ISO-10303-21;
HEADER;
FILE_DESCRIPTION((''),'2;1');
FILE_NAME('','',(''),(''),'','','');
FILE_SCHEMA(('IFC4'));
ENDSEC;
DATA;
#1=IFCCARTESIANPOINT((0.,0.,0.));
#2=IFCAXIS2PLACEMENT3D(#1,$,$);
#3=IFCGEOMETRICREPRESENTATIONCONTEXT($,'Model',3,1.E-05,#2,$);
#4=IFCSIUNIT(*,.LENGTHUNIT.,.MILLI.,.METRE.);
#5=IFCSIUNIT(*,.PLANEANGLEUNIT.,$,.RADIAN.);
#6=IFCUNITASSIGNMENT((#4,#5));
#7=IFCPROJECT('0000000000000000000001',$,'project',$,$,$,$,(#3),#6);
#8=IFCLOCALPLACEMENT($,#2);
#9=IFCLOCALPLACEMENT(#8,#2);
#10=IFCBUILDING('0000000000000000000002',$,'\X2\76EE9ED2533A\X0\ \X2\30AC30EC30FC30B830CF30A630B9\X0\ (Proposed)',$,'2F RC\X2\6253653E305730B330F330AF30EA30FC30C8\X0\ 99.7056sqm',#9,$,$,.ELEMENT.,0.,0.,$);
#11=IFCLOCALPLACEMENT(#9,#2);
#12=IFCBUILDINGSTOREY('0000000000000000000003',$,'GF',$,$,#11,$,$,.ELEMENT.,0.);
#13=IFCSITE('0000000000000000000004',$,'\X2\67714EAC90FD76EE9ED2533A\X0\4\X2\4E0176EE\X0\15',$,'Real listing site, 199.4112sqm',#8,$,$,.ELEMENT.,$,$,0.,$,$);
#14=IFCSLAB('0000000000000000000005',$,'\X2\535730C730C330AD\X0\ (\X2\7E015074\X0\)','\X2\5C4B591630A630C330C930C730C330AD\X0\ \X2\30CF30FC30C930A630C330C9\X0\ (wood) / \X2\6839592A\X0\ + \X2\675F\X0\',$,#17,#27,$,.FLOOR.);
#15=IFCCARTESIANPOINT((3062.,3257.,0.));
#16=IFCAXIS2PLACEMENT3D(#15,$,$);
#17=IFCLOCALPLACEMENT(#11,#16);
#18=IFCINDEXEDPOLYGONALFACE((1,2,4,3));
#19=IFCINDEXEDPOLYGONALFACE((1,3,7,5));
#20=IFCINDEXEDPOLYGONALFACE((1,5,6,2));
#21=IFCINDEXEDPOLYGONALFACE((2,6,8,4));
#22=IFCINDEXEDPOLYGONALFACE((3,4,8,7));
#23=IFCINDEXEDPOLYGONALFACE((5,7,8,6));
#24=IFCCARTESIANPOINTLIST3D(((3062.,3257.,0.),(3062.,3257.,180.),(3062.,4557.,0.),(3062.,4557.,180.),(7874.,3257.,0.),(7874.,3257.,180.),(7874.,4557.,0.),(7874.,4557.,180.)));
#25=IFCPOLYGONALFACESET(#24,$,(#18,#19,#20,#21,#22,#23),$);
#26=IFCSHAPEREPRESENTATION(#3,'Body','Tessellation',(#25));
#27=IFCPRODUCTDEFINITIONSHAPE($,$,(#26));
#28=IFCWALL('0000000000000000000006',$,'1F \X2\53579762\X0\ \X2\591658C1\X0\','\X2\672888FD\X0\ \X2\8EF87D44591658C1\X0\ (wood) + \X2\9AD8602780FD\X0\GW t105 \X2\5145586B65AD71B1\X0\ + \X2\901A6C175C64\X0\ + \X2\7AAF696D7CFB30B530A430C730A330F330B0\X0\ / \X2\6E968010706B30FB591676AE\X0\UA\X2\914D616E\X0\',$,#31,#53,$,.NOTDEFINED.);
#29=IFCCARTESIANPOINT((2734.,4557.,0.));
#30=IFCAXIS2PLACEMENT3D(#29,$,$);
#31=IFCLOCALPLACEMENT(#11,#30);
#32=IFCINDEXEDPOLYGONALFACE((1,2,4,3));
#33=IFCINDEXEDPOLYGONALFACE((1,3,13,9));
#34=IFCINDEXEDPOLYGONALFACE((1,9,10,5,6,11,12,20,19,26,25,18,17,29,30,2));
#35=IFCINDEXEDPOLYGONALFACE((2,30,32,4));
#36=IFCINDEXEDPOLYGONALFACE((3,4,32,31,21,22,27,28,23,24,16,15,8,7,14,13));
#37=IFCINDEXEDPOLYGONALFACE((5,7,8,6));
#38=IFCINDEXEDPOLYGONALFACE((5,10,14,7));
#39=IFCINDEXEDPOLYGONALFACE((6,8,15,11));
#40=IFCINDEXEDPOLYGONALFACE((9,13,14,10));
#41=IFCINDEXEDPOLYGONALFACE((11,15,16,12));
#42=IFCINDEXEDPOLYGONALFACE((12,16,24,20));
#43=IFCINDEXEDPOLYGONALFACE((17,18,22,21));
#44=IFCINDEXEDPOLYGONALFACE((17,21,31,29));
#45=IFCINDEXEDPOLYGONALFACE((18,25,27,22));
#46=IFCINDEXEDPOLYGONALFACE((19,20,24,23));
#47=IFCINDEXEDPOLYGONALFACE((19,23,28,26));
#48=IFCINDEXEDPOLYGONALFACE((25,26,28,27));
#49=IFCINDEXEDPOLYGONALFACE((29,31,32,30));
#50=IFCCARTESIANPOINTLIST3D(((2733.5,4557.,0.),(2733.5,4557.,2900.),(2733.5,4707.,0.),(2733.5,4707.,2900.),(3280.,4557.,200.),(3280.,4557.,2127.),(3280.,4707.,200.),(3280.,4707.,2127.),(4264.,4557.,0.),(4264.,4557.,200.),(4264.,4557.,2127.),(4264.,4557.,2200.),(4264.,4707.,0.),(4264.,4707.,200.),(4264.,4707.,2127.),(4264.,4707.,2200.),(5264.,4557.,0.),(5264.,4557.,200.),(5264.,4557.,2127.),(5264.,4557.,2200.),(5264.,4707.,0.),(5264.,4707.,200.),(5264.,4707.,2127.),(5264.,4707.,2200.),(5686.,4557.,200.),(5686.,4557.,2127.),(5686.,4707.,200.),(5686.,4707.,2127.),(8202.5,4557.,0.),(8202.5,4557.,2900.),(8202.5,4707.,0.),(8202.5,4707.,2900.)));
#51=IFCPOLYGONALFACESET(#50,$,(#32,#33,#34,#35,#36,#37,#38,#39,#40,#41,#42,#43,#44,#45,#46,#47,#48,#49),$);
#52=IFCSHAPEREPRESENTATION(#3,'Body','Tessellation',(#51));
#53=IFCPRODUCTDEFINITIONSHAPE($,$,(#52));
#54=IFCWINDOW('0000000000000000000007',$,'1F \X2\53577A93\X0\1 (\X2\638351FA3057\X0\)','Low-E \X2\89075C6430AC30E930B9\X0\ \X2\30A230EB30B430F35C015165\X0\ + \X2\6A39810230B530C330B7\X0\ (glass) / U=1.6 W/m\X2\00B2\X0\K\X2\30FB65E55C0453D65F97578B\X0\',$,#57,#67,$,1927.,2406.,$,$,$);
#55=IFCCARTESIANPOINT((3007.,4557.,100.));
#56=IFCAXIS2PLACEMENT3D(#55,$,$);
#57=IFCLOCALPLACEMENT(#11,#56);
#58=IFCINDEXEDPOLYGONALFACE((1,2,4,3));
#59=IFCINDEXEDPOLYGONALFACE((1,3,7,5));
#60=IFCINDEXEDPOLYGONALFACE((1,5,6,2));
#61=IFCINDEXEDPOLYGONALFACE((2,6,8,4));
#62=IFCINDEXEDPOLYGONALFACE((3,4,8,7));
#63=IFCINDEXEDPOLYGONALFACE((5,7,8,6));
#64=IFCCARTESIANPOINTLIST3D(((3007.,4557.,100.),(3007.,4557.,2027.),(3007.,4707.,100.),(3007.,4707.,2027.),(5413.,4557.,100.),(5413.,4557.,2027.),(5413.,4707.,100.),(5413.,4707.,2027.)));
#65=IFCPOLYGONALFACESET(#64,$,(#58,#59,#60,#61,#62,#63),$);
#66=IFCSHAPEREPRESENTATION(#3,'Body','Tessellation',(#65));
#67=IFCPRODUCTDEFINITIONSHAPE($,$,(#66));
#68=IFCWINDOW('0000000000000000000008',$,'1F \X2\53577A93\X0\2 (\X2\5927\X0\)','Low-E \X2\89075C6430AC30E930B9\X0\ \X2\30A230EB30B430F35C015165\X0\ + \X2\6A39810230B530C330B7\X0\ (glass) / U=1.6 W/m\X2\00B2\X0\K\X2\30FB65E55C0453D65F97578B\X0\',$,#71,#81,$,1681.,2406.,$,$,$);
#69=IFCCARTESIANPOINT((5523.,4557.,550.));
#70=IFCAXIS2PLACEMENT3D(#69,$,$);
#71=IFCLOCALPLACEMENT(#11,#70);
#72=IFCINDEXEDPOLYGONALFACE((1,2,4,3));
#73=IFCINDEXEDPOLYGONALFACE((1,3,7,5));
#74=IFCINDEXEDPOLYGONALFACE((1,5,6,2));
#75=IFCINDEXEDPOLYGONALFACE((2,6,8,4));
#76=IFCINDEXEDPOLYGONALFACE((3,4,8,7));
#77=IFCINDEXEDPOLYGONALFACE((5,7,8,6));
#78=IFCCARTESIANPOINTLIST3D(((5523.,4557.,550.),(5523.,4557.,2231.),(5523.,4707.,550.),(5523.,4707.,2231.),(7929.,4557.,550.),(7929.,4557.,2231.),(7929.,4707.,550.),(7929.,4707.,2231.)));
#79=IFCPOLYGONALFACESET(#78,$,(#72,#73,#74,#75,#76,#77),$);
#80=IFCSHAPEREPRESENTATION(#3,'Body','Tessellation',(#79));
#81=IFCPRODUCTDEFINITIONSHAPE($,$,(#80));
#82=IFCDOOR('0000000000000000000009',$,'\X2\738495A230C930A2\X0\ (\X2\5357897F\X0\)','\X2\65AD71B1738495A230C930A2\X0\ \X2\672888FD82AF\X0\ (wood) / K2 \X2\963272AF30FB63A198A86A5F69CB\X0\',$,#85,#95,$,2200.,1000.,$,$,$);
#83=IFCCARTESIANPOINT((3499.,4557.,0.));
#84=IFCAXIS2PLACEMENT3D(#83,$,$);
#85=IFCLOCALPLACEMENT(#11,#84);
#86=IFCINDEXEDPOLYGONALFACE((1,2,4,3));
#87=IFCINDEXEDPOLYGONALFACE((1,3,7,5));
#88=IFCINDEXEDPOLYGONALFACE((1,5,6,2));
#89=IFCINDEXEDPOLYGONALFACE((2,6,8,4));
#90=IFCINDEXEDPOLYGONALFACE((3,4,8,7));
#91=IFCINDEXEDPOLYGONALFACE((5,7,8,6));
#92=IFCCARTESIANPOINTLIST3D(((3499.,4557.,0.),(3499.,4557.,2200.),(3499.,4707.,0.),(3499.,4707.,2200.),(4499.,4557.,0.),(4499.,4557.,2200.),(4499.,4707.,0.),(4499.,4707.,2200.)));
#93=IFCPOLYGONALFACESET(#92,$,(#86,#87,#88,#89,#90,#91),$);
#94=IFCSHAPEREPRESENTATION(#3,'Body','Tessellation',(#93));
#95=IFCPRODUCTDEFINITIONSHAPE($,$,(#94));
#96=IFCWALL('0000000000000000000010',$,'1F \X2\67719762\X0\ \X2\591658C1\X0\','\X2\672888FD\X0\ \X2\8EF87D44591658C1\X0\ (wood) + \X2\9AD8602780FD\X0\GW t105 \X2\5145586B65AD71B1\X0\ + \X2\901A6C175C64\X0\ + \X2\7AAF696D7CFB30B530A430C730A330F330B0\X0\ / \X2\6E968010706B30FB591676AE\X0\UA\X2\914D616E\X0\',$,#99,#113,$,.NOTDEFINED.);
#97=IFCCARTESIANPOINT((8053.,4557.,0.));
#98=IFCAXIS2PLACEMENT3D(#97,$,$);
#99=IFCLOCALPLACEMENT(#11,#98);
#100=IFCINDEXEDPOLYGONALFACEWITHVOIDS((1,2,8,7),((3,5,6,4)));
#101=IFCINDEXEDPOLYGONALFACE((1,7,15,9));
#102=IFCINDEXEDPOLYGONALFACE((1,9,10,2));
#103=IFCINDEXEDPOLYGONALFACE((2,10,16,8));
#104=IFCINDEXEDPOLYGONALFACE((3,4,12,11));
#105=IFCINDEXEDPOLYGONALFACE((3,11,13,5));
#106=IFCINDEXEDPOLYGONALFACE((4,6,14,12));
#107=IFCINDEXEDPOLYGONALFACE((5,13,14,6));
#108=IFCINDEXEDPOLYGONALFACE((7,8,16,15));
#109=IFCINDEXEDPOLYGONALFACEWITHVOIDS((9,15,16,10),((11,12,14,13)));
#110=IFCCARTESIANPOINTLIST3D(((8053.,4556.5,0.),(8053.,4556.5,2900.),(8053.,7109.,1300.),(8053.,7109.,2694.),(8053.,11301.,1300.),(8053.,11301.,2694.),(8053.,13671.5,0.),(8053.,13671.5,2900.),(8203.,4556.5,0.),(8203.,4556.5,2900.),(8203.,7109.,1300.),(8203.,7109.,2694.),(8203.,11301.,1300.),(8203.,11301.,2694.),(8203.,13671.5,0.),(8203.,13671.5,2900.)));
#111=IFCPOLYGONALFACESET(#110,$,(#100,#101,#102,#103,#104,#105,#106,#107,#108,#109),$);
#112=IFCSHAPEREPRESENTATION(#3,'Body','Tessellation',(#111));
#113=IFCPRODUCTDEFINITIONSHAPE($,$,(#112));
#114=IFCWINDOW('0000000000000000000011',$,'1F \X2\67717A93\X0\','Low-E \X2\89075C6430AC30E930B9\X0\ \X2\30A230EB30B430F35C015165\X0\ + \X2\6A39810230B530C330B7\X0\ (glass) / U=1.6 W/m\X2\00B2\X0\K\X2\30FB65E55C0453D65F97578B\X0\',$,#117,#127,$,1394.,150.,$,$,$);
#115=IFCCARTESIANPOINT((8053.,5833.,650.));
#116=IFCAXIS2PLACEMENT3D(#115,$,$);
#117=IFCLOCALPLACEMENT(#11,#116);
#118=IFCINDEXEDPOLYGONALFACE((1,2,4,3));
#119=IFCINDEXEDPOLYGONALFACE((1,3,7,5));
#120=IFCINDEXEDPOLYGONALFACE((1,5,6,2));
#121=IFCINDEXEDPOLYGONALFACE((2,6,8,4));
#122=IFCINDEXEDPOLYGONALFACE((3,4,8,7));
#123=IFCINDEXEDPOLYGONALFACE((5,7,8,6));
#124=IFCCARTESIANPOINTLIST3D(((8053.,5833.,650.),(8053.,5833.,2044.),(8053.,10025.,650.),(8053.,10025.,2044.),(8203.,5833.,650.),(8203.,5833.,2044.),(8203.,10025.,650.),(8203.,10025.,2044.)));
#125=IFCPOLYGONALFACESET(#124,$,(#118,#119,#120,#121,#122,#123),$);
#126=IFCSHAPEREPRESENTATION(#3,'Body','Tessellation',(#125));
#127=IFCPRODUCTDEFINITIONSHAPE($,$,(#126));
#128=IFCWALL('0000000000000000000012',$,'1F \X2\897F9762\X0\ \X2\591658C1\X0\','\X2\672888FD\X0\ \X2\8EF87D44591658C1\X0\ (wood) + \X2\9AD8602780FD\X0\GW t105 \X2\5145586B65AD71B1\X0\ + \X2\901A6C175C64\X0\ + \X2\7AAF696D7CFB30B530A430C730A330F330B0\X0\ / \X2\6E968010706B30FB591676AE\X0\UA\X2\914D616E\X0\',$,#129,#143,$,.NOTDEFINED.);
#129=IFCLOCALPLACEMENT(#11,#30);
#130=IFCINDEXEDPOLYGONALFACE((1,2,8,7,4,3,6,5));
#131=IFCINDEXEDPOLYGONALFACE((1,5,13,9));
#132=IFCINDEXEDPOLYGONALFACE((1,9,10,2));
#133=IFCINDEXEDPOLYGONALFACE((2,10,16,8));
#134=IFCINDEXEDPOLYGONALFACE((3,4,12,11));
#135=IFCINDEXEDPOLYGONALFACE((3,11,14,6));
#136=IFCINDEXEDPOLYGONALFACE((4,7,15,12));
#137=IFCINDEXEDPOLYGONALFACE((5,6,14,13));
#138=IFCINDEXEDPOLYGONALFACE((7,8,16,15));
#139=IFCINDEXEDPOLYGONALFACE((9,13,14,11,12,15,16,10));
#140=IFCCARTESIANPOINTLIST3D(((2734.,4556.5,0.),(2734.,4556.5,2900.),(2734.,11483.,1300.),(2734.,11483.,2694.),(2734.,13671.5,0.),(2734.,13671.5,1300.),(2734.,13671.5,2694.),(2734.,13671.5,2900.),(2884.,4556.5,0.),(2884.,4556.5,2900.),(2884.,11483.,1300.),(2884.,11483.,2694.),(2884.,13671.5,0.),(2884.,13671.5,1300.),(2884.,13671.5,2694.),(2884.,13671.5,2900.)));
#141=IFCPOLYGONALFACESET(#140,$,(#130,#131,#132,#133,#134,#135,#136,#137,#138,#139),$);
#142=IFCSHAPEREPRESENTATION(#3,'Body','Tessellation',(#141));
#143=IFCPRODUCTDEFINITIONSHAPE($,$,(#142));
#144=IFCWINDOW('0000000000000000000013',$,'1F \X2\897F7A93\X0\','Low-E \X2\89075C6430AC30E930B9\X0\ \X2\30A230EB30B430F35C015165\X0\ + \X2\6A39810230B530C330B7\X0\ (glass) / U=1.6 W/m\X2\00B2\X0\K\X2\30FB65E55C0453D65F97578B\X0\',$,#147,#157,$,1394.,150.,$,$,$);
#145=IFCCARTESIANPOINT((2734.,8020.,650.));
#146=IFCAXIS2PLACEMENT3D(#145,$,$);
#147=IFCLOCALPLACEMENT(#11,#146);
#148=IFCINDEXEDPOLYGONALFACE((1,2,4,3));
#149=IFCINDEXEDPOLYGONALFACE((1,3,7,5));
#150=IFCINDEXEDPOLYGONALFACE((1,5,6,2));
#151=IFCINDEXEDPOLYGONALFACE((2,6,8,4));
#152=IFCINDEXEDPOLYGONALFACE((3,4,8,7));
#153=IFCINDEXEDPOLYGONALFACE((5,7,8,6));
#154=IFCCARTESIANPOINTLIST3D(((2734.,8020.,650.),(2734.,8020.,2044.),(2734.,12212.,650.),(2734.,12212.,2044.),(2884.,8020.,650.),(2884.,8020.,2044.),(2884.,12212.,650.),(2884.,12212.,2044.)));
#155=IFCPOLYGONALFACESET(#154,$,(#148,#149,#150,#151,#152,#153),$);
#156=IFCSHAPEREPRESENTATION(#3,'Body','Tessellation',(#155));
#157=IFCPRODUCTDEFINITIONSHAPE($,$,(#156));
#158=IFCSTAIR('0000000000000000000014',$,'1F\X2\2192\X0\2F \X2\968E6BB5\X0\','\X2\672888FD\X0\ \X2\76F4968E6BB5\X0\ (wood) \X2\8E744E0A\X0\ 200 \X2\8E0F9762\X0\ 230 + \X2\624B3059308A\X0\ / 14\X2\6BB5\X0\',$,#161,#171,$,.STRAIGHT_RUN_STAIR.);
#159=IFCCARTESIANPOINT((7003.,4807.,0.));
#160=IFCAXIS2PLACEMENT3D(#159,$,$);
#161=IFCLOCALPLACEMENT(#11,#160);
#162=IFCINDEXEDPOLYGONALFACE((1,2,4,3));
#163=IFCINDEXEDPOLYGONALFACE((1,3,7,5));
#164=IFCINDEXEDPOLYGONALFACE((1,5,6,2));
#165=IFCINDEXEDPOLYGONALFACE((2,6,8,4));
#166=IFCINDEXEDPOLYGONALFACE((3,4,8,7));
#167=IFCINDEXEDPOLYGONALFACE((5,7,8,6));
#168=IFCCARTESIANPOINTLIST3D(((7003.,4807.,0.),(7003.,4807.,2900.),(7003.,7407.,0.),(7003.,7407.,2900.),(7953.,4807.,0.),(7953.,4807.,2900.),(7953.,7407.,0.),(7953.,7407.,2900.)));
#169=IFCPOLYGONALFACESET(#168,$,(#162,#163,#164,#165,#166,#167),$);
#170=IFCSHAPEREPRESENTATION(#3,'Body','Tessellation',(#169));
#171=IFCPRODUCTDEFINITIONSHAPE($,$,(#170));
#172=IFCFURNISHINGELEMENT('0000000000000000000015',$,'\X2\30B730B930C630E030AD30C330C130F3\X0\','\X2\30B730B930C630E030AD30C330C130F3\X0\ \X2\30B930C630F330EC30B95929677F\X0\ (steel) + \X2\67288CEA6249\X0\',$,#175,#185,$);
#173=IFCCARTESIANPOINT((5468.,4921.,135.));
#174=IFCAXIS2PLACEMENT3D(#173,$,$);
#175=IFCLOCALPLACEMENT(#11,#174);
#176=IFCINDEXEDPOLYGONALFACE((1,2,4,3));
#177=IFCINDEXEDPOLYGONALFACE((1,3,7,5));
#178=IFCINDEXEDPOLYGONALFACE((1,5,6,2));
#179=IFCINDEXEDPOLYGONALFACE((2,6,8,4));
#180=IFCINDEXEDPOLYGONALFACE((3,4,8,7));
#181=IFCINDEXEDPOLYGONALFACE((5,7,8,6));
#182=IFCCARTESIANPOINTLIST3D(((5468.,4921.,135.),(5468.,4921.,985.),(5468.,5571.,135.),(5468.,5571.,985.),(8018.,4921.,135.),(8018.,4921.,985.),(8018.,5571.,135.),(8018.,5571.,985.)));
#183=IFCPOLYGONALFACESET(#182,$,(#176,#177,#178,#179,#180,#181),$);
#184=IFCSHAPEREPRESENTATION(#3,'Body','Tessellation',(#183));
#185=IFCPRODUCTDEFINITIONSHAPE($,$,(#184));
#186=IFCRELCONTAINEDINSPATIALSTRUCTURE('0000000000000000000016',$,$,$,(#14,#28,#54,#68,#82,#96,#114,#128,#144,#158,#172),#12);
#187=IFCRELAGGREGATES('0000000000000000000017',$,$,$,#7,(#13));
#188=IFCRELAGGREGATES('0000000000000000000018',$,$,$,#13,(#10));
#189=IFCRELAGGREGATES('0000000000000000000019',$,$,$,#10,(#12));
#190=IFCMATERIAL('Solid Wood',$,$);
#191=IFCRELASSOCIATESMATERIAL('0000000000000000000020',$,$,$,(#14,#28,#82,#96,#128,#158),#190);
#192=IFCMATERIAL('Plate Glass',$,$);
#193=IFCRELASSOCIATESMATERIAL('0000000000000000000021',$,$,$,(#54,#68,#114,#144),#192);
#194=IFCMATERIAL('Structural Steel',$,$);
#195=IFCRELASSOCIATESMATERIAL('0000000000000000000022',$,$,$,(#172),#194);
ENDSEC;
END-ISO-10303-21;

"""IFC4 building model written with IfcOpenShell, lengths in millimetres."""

from ifc_helpers import new_model, si_unit, frame, frame_2d, origin, place, context, project, spatial, rectangle, extrude, material, element, fill, save


model = new_model("IFC4")

# Units and contexts
model_context = context("Model", 3, precision=1e-05, world=origin())
ifc_project = project(units=[si_unit("LENGTHUNIT", "METRE", prefix="MILLI"), si_unit("PLANEANGLEUNIT", "RADIAN")], contexts=[model_context])

# Site, building, storey
site_placement = place(None, origin())
site = spatial("IfcSite", under=ifc_project, at=site_placement, Name="東京都目黒区4丁目15", ObjectType="Real listing site, 199.4112sqm", CompositionType="ELEMENT", RefElevation=0.0)
building_placement = place(site_placement, origin())
building = spatial("IfcBuilding", under=site, at=building_placement, Name="目黒区 ガレージハウス (Proposed)", ObjectType="2F RC打放しコンクリート 99.7056sqm", CompositionType="ELEMENT", ElevationOfRefHeight=0.0, ElevationOfTerrain=0.0)
storey_placement = place(building_placement, origin())
storey = spatial("IfcBuildingStorey", under=building, at=storey_placement, Name="GF", CompositionType="ELEMENT", Elevation=0.0)

# Slab
ifc_material_1 = material(Name="Solid Wood")
slab_1_placement = place(storey_placement, frame((3062.0, 3257.0, 0.0)))
element("IfcSlab", 1, at=slab_1_placement, inside=storey, material=ifc_material_1, Name="南デッキ (縁側)", Description="屋外ウッドデッキ ハードウッド (wood) / 根太 + 束", PredefinedType="FLOOR", context=model_context, shape_type="SweptSolid", body=[
    extrude(rectangle(XDim=4812.0, YDim=1300.0, at=frame_2d((2406.0, 650.0))), frame((3062.0, 3257.0, 0.0)), (0.0, 0.0, 1.0), 180.0),
])

# Wall, openings, windows, door
wall_1_placement = place(storey_placement, frame((2734.0, 4557.0, 0.0)))
wall_1 = element("IfcWall", 2, at=wall_1_placement, inside=storey, material=ifc_material_1, Name="1F 南面 外壁", Description="木製 軸組外壁 (wood) + 高性能GW t105 充填断熱 + 通気層 + 窯業系サイディング / 準耐火・外皮UA配慮", PredefinedType="NOTDEFINED", context=model_context, shape_type="SweptSolid", body=[
    extrude(rectangle(XDim=5469.0, YDim=150.0, at=frame_2d((2734.0, 75.0))), frame((2734.0, 4557.0, 0.0)), (0.0, 0.0, 1.0), 2900.0),
])
opening_1_placement = place(storey_placement, frame((3007.0, 4557.0, 100.0)))
opening_1 = element("IfcOpeningElement", 3, at=opening_1_placement, cuts=wall_1, PredefinedType="NOTDEFINED", context=model_context, shape_type="SweptSolid", body=[
    extrude(rectangle(XDim=2406.0, YDim=150.0, at=frame_2d((1203.0, 75.0))), frame((3007.0, 4557.0, 100.0)), (0.0, 0.0, 1.0), 1927.0),
])
opening_2_placement = place(storey_placement, frame((5523.0, 4557.0, 550.0)))
opening_2 = element("IfcOpeningElement", 4, at=opening_2_placement, cuts=wall_1, PredefinedType="NOTDEFINED", context=model_context, shape_type="SweptSolid", body=[
    extrude(rectangle(XDim=2406.0, YDim=150.0, at=frame_2d((1203.0, 75.0))), frame((5523.0, 4557.0, 550.0)), (0.0, 0.0, 1.0), 1681.0),
])
opening_3_placement = place(storey_placement, frame((3499.0, 4557.0, 0.0)))
opening_3 = element("IfcOpeningElement", 5, at=opening_3_placement, cuts=wall_1, PredefinedType="NOTDEFINED", context=model_context, shape_type="SweptSolid", body=[
    extrude(rectangle(XDim=1000.0, YDim=150.0, at=frame_2d((500.0, 75.0))), frame((3499.0, 4557.0, 0.0)), (0.0, 0.0, 1.0), 2200.0),
])
ifc_material_2 = material(Name="Plate Glass")
window_1_placement = place(storey_placement, frame((3007.0, 4557.0, 100.0)))
window_1 = element("IfcWindow", 6, at=window_1_placement, inside=storey, material=ifc_material_2, Name="1F 南窓1 (掃出し)", Description="Low-E 複層ガラス アルゴン封入 + 樹脂サッシ (glass) / U=1.6 W/m²K・日射取得型", OverallHeight=1927.0, OverallWidth=2406.0, context=model_context, shape_type="SweptSolid", body=[
    extrude(rectangle(XDim=2406.0, YDim=150.0, at=frame_2d((1203.0, 75.0))), frame((3007.0, 4557.0, 100.0)), (0.0, 0.0, 1.0), 1927.0),
])
fill(opening_1, window_1)
window_2_placement = place(storey_placement, frame((5523.0, 4557.0, 550.0)))
window_2 = element("IfcWindow", 7, at=window_2_placement, inside=storey, material=ifc_material_2, Name="1F 南窓2 (大)", Description="Low-E 複層ガラス アルゴン封入 + 樹脂サッシ (glass) / U=1.6 W/m²K・日射取得型", OverallHeight=1681.0, OverallWidth=2406.0, context=model_context, shape_type="SweptSolid", body=[
    extrude(rectangle(XDim=2406.0, YDim=150.0, at=frame_2d((1203.0, 75.0))), frame((5523.0, 4557.0, 550.0)), (0.0, 0.0, 1.0), 1681.0),
])
fill(opening_2, window_2)
door_placement = place(storey_placement, frame((3499.0, 4557.0, 0.0)))
door = element("IfcDoor", 8, at=door_placement, inside=storey, material=ifc_material_1, Name="玄関ドア (南西)", Description="断熱玄関ドア 木製芯 (wood) / K2 防犯・採風機構", OverallHeight=2200.0, OverallWidth=1000.0, context=model_context, shape_type="SweptSolid", body=[
    extrude(rectangle(XDim=1000.0, YDim=150.0, at=frame_2d((500.0, 75.0))), frame((3499.0, 4557.0, 0.0)), (0.0, 0.0, 1.0), 2200.0),
])
fill(opening_3, door)

# Walls, openings, windows
wall_2_placement = place(storey_placement, frame((8053.0, 4557.0, 0.0)))
wall_2 = element("IfcWall", 9, at=wall_2_placement, inside=storey, material=ifc_material_1, Name="1F 東面 外壁", Description="木製 軸組外壁 (wood) + 高性能GW t105 充填断熱 + 通気層 + 窯業系サイディング / 準耐火・外皮UA配慮", PredefinedType="NOTDEFINED", context=model_context, shape_type="SweptSolid", body=[
    extrude(rectangle(XDim=150.0, YDim=9115.0, at=frame_2d((75.0, 4557.0))), frame((8053.0, 4557.0, 0.0)), (0.0, 0.0, 1.0), 2900.0),
])
opening_4_placement = place(storey_placement, frame((8053.0, 5833.0, 650.0)))
opening_4 = element("IfcOpeningElement", 10, at=opening_4_placement, cuts=wall_2, PredefinedType="NOTDEFINED", context=model_context, shape_type="SweptSolid", body=[
    extrude(rectangle(XDim=150.0, YDim=4192.0, at=frame_2d((75.0, 2096.0))), frame((8053.0, 5833.0, 650.0)), (0.0, 0.0, 1.0), 1394.0),
])
window_3_placement = place(storey_placement, frame((8053.0, 5833.0, 650.0)))
window_3 = element("IfcWindow", 11, at=window_3_placement, inside=storey, material=ifc_material_2, Name="1F 東窓", Description="Low-E 複層ガラス アルゴン封入 + 樹脂サッシ (glass) / U=1.6 W/m²K・日射取得型", OverallHeight=1394.0, OverallWidth=150.0, context=model_context, shape_type="SweptSolid", body=[
    extrude(rectangle(XDim=150.0, YDim=4192.0, at=frame_2d((75.0, 2096.0))), frame((8053.0, 5833.0, 650.0)), (0.0, 0.0, 1.0), 1394.0),
])
fill(opening_4, window_3)
wall_3_placement = place(storey_placement, frame((2734.0, 4557.0, 0.0)))
wall_3 = element("IfcWall", 12, at=wall_3_placement, inside=storey, material=ifc_material_1, Name="1F 西面 外壁", Description="木製 軸組外壁 (wood) + 高性能GW t105 充填断熱 + 通気層 + 窯業系サイディング / 準耐火・外皮UA配慮", PredefinedType="NOTDEFINED", context=model_context, shape_type="SweptSolid", body=[
    extrude(rectangle(XDim=150.0, YDim=9115.0, at=frame_2d((75.0, 4557.0))), frame((2734.0, 4557.0, 0.0)), (0.0, 0.0, 1.0), 2900.0),
])
opening_5_placement = place(storey_placement, frame((2734.0, 8020.0, 650.0)))
opening_5 = element("IfcOpeningElement", 13, at=opening_5_placement, cuts=wall_3, PredefinedType="NOTDEFINED", context=model_context, shape_type="SweptSolid", body=[
    extrude(rectangle(XDim=150.0, YDim=4192.0, at=frame_2d((75.0, 2096.0))), frame((2734.0, 8020.0, 650.0)), (0.0, 0.0, 1.0), 1394.0),
])
window_4_placement = place(storey_placement, frame((2734.0, 8020.0, 650.0)))
window_4 = element("IfcWindow", 14, at=window_4_placement, inside=storey, material=ifc_material_2, Name="1F 西窓", Description="Low-E 複層ガラス アルゴン封入 + 樹脂サッシ (glass) / U=1.6 W/m²K・日射取得型", OverallHeight=1394.0, OverallWidth=150.0, context=model_context, shape_type="SweptSolid", body=[
    extrude(rectangle(XDim=150.0, YDim=4192.0, at=frame_2d((75.0, 2096.0))), frame((2734.0, 8020.0, 650.0)), (0.0, 0.0, 1.0), 1394.0),
])
fill(opening_5, window_4)

# Stair
stair_placement = place(storey_placement, frame((7003.0, 4807.0, 0.0)))
element("IfcStair", 15, at=stair_placement, inside=storey, material=ifc_material_1, Name="1F→2F 階段", Description="木製 直階段 (wood) 蹴上 200 踏面 230 + 手すり / 14段", PredefinedType="STRAIGHT_RUN_STAIR", context=model_context, shape_type="SweptSolid", body=[
    extrude(rectangle(XDim=950.0, YDim=2600.0, at=frame_2d((475.0, 1300.0))), frame((7003.0, 4807.0, 0.0)), (0.0, 0.0, 1.0), 2900.0),
])

# Furnishing element
ifc_material_3 = material(Name="Structural Steel")
furnishing_placement = place(storey_placement, frame((5468.0, 4921.0, 135.0)))
element("IfcFurnishingElement", 16, at=furnishing_placement, inside=storey, material=ifc_material_3, Name="システムキッチン", Description="システムキッチン ステンレス天板 (steel) + 木質扉", context=model_context, shape_type="SweptSolid", body=[
    extrude(rectangle(XDim=2550.0, YDim=650.0, at=frame_2d((1275.0, 325.0))), frame((5468.0, 4921.0, 135.0)), (0.0, 0.0, 1.0), 850.0),
])

save(model, "model.ifc")
